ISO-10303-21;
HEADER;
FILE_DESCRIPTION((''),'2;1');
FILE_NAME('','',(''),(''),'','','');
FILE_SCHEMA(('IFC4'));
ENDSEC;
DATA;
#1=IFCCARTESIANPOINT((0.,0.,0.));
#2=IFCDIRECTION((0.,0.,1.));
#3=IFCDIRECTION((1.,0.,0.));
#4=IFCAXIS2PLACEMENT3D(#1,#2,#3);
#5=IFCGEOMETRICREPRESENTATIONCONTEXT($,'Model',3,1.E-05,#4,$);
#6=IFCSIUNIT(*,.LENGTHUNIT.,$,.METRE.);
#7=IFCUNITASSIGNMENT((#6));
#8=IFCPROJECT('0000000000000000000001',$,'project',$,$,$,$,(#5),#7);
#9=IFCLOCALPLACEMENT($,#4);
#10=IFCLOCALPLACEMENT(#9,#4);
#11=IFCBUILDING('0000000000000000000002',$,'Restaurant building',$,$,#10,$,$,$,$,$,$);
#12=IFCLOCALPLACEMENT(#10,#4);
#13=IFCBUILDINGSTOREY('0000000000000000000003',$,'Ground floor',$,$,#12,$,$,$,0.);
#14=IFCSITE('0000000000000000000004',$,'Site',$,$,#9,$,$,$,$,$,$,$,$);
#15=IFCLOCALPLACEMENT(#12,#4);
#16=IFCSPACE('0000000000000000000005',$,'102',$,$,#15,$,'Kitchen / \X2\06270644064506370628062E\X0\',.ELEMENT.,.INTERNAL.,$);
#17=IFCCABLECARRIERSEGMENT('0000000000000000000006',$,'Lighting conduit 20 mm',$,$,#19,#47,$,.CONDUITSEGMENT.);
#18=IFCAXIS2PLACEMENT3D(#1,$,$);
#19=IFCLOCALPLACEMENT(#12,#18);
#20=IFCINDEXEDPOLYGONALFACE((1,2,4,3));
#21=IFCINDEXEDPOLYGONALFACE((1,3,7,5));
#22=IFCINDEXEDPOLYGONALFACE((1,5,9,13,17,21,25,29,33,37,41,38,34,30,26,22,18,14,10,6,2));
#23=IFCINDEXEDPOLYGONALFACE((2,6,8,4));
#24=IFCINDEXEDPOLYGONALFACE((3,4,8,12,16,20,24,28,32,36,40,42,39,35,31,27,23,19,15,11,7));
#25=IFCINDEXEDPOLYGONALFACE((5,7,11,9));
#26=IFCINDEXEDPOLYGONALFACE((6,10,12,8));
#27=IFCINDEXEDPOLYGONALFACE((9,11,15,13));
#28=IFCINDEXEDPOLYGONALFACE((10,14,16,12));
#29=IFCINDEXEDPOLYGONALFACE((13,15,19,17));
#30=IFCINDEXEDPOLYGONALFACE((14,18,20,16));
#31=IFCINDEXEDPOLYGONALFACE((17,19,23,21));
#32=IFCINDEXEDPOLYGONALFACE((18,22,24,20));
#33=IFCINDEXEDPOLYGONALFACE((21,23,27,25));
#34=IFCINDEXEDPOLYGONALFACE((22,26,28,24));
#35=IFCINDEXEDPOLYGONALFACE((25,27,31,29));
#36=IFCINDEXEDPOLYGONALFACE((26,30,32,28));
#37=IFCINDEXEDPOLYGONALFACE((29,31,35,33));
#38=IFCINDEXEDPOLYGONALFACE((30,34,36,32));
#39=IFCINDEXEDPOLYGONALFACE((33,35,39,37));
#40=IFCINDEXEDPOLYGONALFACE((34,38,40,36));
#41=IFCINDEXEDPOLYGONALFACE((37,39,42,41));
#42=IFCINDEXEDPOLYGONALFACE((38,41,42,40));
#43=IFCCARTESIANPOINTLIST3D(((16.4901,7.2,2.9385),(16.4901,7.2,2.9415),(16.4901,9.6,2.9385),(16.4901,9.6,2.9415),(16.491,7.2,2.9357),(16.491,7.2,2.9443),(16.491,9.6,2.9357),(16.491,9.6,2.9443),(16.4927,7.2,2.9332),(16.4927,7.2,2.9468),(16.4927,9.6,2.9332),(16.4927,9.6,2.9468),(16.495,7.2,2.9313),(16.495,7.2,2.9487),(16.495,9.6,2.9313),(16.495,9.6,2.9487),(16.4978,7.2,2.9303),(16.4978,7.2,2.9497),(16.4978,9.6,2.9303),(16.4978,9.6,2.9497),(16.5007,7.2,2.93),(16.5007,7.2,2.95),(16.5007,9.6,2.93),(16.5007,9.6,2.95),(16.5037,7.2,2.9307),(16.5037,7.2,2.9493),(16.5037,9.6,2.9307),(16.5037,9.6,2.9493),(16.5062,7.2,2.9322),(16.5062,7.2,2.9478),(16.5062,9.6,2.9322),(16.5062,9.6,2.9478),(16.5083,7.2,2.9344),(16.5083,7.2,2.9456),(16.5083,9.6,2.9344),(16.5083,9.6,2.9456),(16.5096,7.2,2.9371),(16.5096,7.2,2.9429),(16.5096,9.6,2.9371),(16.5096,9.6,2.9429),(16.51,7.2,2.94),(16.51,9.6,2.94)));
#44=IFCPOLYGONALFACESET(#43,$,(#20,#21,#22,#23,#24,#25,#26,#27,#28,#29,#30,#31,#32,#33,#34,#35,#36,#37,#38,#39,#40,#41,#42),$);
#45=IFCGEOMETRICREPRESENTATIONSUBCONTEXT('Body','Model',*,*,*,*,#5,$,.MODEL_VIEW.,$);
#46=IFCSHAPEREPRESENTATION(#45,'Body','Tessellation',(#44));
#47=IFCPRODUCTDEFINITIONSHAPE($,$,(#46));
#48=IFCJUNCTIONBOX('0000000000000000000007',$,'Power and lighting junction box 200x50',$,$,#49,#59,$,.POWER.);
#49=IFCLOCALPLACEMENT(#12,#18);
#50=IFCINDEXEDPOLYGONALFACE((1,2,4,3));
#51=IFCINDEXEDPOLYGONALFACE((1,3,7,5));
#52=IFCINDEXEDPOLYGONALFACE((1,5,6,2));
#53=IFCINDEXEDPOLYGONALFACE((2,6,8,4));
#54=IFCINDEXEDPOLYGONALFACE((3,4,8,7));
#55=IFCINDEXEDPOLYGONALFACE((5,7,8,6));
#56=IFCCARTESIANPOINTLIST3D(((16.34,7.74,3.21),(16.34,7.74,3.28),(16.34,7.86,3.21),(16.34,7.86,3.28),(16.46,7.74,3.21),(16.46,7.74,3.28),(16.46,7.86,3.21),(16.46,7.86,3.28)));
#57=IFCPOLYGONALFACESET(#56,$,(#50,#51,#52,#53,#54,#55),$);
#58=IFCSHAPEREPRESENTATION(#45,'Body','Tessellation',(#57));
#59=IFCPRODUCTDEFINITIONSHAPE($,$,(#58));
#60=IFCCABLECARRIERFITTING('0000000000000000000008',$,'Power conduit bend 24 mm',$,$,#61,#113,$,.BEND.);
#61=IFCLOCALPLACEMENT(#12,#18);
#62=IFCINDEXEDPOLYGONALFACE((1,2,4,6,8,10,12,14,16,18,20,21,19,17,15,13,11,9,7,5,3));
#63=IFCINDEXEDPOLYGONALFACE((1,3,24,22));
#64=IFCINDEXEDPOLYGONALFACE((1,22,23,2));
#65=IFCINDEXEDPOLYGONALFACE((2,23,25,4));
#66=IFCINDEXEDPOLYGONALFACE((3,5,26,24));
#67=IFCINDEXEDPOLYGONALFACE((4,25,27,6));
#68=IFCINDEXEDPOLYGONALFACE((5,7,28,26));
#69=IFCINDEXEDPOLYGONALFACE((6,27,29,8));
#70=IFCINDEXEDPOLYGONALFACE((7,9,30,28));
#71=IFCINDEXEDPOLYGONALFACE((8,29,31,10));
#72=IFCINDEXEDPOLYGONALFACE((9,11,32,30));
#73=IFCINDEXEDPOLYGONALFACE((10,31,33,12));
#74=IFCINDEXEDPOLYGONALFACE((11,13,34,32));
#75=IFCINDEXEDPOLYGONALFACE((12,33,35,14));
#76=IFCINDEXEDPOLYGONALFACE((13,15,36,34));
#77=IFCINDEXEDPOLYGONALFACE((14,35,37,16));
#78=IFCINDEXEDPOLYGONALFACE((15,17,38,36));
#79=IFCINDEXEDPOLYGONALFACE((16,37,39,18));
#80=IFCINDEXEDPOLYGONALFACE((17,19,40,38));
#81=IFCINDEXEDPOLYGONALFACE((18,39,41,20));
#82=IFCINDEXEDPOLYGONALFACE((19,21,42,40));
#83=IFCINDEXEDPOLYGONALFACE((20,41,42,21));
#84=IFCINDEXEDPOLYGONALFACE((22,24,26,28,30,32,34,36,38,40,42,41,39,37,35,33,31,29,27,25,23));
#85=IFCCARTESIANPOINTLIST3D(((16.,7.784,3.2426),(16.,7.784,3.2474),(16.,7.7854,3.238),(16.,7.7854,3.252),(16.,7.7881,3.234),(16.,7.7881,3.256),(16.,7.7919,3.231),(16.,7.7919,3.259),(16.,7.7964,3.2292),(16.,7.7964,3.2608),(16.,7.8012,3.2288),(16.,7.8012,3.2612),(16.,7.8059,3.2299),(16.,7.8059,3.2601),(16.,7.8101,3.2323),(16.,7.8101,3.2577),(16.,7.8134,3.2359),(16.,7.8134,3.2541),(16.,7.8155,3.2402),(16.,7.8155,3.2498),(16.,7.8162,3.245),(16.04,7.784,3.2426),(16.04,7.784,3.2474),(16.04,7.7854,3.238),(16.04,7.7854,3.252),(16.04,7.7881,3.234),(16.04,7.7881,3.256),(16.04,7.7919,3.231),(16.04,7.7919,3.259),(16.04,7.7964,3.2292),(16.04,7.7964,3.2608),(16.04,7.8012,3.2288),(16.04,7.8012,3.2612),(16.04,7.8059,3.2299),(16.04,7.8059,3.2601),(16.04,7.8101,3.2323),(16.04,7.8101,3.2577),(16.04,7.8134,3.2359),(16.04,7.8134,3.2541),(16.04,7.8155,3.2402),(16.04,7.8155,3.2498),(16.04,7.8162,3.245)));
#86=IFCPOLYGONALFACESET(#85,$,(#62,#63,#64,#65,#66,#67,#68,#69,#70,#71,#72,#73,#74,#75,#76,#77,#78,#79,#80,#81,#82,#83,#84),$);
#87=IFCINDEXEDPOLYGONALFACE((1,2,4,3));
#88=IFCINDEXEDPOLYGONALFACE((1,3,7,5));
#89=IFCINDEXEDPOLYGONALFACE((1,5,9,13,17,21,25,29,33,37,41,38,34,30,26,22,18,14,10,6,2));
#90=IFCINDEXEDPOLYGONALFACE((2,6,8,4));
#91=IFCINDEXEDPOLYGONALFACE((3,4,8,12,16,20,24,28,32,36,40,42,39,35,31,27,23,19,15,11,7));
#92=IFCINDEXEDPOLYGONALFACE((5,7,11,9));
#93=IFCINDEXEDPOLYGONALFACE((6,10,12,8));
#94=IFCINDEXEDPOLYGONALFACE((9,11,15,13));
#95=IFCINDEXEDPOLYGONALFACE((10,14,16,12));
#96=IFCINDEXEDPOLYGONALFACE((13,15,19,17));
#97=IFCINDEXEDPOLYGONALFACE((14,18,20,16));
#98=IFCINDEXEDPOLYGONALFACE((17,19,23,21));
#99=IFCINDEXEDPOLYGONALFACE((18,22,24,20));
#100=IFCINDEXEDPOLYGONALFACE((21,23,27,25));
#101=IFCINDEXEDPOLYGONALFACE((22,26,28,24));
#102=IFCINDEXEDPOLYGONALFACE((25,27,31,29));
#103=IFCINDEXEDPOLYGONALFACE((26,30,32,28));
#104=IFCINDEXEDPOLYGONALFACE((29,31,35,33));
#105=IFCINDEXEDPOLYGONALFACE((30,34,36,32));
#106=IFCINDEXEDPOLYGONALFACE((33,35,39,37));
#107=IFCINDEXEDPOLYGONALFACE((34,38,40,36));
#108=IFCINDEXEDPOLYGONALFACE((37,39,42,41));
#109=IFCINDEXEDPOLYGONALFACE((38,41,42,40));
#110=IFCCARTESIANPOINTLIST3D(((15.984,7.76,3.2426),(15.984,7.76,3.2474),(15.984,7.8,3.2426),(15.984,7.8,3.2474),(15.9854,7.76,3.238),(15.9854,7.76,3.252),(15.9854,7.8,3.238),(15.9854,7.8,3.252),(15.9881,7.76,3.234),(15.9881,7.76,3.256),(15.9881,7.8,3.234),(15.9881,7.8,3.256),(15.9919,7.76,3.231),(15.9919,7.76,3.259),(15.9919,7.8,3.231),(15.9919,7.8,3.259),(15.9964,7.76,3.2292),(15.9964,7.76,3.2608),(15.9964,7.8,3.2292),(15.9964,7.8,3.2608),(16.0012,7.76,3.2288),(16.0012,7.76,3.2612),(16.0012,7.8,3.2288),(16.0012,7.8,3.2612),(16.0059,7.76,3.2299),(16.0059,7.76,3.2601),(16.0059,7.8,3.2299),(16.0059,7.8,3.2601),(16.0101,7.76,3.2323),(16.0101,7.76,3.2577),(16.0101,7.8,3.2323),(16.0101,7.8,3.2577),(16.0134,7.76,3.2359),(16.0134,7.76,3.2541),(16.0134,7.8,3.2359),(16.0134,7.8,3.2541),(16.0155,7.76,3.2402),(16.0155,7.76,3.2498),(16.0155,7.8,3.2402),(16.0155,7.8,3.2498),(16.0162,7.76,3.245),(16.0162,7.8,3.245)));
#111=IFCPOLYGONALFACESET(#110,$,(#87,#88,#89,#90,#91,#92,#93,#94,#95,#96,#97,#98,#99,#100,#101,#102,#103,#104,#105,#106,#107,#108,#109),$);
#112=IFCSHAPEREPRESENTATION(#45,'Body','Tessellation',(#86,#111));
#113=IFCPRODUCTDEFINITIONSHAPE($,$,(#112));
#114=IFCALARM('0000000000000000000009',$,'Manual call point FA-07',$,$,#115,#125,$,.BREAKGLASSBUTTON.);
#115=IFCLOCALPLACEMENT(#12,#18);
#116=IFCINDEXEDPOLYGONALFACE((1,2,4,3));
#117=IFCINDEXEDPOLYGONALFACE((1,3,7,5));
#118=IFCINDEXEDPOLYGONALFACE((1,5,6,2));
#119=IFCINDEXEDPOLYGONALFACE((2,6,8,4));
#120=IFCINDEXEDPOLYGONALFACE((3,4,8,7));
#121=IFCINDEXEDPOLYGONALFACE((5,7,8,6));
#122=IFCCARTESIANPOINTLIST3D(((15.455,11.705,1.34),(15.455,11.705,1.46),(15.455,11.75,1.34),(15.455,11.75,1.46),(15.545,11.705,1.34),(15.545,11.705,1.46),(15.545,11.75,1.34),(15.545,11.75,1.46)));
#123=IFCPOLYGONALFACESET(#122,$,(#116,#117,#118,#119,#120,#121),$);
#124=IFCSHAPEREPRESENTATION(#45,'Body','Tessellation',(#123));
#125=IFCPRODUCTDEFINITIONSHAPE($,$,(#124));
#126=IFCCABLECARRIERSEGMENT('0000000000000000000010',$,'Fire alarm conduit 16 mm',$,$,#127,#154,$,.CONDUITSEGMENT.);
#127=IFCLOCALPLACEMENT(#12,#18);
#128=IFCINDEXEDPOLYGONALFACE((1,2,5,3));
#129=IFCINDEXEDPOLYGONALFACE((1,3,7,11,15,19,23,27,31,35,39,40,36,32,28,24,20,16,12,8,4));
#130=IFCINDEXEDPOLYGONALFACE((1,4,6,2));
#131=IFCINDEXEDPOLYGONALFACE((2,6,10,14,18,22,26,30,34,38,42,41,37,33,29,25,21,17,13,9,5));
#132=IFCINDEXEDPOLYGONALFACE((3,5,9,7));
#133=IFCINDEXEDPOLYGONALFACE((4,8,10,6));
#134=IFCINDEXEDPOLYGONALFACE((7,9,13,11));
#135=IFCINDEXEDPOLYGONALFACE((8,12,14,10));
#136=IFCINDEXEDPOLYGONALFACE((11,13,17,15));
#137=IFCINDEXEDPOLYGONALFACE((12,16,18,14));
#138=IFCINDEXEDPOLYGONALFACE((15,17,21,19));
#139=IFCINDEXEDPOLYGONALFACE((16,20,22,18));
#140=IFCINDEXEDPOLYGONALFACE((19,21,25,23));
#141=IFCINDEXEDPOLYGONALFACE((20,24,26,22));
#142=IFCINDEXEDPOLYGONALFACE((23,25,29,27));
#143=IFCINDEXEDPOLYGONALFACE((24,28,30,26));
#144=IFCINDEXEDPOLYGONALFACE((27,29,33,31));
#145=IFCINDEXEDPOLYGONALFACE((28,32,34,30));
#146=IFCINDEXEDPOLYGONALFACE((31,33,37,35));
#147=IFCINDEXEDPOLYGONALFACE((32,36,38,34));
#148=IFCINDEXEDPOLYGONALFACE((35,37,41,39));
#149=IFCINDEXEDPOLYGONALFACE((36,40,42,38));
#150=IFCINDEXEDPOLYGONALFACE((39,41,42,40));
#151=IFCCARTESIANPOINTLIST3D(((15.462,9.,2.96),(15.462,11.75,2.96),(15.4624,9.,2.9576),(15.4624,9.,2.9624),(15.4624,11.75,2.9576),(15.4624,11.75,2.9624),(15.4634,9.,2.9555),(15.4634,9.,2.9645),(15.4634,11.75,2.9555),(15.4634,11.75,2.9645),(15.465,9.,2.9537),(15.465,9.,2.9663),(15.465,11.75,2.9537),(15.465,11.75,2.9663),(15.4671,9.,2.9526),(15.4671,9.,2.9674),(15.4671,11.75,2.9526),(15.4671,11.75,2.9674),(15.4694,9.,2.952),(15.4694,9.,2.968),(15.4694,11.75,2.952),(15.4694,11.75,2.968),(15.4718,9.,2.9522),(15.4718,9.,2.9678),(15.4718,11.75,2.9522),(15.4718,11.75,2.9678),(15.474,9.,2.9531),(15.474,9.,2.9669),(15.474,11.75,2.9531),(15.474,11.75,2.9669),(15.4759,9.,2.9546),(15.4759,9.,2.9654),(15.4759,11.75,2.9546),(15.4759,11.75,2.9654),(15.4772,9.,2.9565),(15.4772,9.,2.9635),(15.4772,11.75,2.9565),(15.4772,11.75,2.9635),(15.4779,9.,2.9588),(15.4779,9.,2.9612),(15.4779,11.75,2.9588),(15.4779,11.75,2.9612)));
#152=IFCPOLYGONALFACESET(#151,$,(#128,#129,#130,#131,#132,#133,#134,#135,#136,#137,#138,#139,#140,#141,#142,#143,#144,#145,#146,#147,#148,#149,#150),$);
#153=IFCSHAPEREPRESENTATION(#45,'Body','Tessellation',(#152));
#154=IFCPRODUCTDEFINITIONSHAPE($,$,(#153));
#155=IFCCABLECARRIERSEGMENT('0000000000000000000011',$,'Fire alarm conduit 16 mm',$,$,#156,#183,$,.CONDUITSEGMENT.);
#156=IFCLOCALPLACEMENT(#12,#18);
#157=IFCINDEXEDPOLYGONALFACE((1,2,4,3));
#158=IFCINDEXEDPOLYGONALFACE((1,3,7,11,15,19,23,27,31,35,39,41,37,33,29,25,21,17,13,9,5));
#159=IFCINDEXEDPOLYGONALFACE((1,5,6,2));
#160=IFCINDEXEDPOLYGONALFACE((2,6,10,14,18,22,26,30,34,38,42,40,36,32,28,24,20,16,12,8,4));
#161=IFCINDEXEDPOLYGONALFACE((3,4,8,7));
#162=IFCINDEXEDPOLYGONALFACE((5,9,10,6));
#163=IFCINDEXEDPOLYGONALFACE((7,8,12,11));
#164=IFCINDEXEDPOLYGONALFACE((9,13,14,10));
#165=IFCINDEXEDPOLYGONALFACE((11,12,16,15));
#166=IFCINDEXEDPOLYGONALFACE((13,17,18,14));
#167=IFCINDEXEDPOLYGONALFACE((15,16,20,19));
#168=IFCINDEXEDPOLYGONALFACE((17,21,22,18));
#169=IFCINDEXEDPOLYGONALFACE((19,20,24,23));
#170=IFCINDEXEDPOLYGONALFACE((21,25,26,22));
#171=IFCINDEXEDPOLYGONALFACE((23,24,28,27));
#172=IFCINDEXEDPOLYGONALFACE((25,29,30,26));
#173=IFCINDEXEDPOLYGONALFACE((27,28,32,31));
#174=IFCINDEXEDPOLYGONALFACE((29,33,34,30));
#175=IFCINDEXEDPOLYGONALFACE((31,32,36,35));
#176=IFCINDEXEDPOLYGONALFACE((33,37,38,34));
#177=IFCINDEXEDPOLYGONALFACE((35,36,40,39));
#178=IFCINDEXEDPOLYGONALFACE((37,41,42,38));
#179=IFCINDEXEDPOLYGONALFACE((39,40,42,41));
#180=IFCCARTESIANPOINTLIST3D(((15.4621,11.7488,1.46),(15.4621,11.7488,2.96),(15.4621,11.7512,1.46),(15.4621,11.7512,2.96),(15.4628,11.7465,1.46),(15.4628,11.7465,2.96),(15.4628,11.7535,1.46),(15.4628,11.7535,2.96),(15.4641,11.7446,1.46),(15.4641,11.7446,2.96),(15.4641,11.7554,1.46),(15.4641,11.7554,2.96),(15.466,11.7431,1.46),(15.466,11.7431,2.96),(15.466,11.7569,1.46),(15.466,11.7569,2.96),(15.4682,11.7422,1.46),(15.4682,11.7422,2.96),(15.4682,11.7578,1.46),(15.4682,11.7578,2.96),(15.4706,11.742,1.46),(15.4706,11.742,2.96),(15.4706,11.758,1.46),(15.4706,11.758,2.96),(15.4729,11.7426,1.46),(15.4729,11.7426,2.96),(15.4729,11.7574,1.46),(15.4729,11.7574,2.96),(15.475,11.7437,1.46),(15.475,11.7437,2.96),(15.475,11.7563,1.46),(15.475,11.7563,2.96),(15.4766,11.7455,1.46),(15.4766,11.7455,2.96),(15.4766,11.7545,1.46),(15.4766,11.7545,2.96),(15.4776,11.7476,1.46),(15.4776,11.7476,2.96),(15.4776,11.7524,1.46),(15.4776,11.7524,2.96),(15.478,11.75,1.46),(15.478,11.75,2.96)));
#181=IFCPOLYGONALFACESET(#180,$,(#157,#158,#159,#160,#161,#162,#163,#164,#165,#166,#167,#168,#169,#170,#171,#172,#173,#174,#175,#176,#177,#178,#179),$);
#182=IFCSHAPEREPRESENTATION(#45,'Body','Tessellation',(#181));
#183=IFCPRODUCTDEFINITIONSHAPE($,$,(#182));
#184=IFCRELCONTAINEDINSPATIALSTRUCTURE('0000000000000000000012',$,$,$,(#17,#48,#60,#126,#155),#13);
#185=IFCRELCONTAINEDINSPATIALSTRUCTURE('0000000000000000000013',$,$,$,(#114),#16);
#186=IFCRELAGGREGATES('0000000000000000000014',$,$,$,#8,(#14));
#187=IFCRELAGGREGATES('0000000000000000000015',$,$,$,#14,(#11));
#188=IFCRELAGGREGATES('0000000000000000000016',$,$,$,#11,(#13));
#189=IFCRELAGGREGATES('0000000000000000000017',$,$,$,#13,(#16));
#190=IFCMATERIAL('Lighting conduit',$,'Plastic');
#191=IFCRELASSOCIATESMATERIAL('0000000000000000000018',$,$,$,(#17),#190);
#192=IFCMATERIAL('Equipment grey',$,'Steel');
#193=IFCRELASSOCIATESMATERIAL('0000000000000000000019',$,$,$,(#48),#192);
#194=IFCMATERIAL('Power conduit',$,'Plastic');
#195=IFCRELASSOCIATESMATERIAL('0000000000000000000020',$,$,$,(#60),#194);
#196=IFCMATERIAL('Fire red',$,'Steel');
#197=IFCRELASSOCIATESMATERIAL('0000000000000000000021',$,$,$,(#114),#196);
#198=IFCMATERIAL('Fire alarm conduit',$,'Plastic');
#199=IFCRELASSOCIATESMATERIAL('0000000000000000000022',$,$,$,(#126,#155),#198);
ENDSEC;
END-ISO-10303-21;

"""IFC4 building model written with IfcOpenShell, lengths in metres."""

from ifc_helpers import new_model, si_unit, frame, origin_with_axes, origin_2d, place, context, subcontext, project, spatial, rectangle, circle, extrude, material, element, save


model = new_model("IFC4")

# Units and contexts
model_context = context("Model", 3, precision=1e-05, world=origin_with_axes())
body_context = subcontext(model_context, "Body", "Model", "MODEL_VIEW")
ifc_project = project(units=[si_unit("LENGTHUNIT", "METRE")], contexts=[model_context])

# Site, building, storey, space
site_placement = place(None, origin_with_axes())
site = spatial("IfcSite", under=ifc_project, at=site_placement, Name="Site")
building_placement = place(site_placement, origin_with_axes())
building = spatial("IfcBuilding", under=site, at=building_placement, Name="Restaurant building")
storey_placement = place(building_placement, origin_with_axes())
storey = spatial("IfcBuildingStorey", under=building, at=storey_placement, Name="Ground floor", Elevation=0.0)
space_placement = place(storey_placement, origin_with_axes())
space = spatial("IfcSpace", under=storey, at=space_placement, Name="102", LongName="Kitchen / المطبخ", CompositionType="ELEMENT", PredefinedType="INTERNAL")

# Shared definitions
ifc_material_1 = material(Name="Fire red", Category="Steel")

# Shared definitions
ifc_material_2 = material(Name="Equipment grey", Category="Steel")

# Cable carrier segment
ifc_material_3 = material(Name="Power conduit", Category="Plastic")
ifc_material_4 = material(Name="Lighting conduit", Category="Plastic")
cable_carrier_segment_1_placement = place(storey_placement, frame((16.5, 9.6, 2.94)))
element("IfcCableCarrierSegment", 1, at=cable_carrier_segment_1_placement, inside=storey, material=ifc_material_4, Name="Lighting conduit 20 mm", PredefinedType="CONDUITSEGMENT", context=body_context, shape_type="SweptSolid", body=[
    extrude(circle(Radius=0.01, at=origin_2d()), frame((0.0, 0.0, 0.0), z_axis=(0.0, -1.0, 0.0), x_axis=(1.0, 0.0, 0.0)), (0.0, 0.0, 1.0), 2.4),
])

# Junction box
junction_box_placement = place(storey_placement, frame((16.4, 7.8, 3.245)))
element("IfcJunctionBox", 2, at=junction_box_placement, inside=storey, material=ifc_material_2, Name="Power and lighting junction box 200x50", PredefinedType="POWER", context=body_context, shape_type="SweptSolid", body=[
    extrude(rectangle(XDim=0.12, YDim=0.12, at=origin_2d()), frame((0.0, 0.0, -0.035)), (0.0, 0.0, 1.0), 0.07),
])

# Cable carrier fitting
cable_carrier_fitting_1_placement = place(storey_placement, frame((16.0, 7.8, 3.245)))
element("IfcCableCarrierFitting", 3, at=cable_carrier_fitting_1_placement, inside=storey, material=ifc_material_3, Name="Power conduit bend 24 mm", PredefinedType="BEND", context=body_context, shape_type="SweptSolid", body=[
    extrude(circle(Radius=0.0162, at=origin_2d()), frame((0.0, 0.0, 0.0), z_axis=(1.0, 0.0, 0.0), x_axis=(0.0, 1.0, 0.0)), (0.0, 0.0, 1.0), 0.04),
    extrude(circle(Radius=0.0162, at=origin_2d()), frame((0.0, 0.0, 0.0), z_axis=(0.0, -1.0, 0.0), x_axis=(1.0, 0.0, 0.0)), (0.0, 0.0, 1.0), 0.04),
])

# Alarm
alarm_placement = place(storey_placement, frame((15.5, 11.75, 1.4)))
element("IfcAlarm", 4, at=alarm_placement, inside=space, material=ifc_material_1, Name="Manual call point FA-07", PredefinedType="BREAKGLASSBUTTON", context=body_context, shape_type="SweptSolid", body=[
    extrude(rectangle(XDim=0.09, YDim=0.045, at=origin_2d()), frame((0.0, -0.0225, -0.06)), (0.0, 0.0, 1.0), 0.12),
])

# Cable carrier segments
ifc_material_5 = material(Name="Fire alarm conduit", Category="Plastic")
cable_carrier_segment_2_placement = place(storey_placement, frame((15.47, 9.0, 2.96)))
element("IfcCableCarrierSegment", 5, at=cable_carrier_segment_2_placement, inside=storey, material=ifc_material_5, Name="Fire alarm conduit 16 mm", PredefinedType="CONDUITSEGMENT", context=body_context, shape_type="SweptSolid", body=[
    extrude(circle(Radius=0.008, at=origin_2d()), frame((0.0, 0.0, 0.0), z_axis=(0.0, 1.0, 0.0), x_axis=(-1.0, 0.0, 0.0)), (0.0, 0.0, 1.0), 2.75),
])
cable_carrier_segment_3_placement = place(storey_placement, frame((15.47, 11.75, 2.96)))
element("IfcCableCarrierSegment", 6, at=cable_carrier_segment_3_placement, inside=storey, material=ifc_material_5, Name="Fire alarm conduit 16 mm", PredefinedType="CONDUITSEGMENT", context=body_context, shape_type="SweptSolid", body=[
    extrude(circle(Radius=0.008, at=origin_2d()), frame((0.0, 0.0, 0.0), z_axis=(0.0, 0.0, -1.0), x_axis=(1.0, 0.0, 0.0)), (0.0, 0.0, 1.0), 1.5),
])

save(model, "model.ifc")
